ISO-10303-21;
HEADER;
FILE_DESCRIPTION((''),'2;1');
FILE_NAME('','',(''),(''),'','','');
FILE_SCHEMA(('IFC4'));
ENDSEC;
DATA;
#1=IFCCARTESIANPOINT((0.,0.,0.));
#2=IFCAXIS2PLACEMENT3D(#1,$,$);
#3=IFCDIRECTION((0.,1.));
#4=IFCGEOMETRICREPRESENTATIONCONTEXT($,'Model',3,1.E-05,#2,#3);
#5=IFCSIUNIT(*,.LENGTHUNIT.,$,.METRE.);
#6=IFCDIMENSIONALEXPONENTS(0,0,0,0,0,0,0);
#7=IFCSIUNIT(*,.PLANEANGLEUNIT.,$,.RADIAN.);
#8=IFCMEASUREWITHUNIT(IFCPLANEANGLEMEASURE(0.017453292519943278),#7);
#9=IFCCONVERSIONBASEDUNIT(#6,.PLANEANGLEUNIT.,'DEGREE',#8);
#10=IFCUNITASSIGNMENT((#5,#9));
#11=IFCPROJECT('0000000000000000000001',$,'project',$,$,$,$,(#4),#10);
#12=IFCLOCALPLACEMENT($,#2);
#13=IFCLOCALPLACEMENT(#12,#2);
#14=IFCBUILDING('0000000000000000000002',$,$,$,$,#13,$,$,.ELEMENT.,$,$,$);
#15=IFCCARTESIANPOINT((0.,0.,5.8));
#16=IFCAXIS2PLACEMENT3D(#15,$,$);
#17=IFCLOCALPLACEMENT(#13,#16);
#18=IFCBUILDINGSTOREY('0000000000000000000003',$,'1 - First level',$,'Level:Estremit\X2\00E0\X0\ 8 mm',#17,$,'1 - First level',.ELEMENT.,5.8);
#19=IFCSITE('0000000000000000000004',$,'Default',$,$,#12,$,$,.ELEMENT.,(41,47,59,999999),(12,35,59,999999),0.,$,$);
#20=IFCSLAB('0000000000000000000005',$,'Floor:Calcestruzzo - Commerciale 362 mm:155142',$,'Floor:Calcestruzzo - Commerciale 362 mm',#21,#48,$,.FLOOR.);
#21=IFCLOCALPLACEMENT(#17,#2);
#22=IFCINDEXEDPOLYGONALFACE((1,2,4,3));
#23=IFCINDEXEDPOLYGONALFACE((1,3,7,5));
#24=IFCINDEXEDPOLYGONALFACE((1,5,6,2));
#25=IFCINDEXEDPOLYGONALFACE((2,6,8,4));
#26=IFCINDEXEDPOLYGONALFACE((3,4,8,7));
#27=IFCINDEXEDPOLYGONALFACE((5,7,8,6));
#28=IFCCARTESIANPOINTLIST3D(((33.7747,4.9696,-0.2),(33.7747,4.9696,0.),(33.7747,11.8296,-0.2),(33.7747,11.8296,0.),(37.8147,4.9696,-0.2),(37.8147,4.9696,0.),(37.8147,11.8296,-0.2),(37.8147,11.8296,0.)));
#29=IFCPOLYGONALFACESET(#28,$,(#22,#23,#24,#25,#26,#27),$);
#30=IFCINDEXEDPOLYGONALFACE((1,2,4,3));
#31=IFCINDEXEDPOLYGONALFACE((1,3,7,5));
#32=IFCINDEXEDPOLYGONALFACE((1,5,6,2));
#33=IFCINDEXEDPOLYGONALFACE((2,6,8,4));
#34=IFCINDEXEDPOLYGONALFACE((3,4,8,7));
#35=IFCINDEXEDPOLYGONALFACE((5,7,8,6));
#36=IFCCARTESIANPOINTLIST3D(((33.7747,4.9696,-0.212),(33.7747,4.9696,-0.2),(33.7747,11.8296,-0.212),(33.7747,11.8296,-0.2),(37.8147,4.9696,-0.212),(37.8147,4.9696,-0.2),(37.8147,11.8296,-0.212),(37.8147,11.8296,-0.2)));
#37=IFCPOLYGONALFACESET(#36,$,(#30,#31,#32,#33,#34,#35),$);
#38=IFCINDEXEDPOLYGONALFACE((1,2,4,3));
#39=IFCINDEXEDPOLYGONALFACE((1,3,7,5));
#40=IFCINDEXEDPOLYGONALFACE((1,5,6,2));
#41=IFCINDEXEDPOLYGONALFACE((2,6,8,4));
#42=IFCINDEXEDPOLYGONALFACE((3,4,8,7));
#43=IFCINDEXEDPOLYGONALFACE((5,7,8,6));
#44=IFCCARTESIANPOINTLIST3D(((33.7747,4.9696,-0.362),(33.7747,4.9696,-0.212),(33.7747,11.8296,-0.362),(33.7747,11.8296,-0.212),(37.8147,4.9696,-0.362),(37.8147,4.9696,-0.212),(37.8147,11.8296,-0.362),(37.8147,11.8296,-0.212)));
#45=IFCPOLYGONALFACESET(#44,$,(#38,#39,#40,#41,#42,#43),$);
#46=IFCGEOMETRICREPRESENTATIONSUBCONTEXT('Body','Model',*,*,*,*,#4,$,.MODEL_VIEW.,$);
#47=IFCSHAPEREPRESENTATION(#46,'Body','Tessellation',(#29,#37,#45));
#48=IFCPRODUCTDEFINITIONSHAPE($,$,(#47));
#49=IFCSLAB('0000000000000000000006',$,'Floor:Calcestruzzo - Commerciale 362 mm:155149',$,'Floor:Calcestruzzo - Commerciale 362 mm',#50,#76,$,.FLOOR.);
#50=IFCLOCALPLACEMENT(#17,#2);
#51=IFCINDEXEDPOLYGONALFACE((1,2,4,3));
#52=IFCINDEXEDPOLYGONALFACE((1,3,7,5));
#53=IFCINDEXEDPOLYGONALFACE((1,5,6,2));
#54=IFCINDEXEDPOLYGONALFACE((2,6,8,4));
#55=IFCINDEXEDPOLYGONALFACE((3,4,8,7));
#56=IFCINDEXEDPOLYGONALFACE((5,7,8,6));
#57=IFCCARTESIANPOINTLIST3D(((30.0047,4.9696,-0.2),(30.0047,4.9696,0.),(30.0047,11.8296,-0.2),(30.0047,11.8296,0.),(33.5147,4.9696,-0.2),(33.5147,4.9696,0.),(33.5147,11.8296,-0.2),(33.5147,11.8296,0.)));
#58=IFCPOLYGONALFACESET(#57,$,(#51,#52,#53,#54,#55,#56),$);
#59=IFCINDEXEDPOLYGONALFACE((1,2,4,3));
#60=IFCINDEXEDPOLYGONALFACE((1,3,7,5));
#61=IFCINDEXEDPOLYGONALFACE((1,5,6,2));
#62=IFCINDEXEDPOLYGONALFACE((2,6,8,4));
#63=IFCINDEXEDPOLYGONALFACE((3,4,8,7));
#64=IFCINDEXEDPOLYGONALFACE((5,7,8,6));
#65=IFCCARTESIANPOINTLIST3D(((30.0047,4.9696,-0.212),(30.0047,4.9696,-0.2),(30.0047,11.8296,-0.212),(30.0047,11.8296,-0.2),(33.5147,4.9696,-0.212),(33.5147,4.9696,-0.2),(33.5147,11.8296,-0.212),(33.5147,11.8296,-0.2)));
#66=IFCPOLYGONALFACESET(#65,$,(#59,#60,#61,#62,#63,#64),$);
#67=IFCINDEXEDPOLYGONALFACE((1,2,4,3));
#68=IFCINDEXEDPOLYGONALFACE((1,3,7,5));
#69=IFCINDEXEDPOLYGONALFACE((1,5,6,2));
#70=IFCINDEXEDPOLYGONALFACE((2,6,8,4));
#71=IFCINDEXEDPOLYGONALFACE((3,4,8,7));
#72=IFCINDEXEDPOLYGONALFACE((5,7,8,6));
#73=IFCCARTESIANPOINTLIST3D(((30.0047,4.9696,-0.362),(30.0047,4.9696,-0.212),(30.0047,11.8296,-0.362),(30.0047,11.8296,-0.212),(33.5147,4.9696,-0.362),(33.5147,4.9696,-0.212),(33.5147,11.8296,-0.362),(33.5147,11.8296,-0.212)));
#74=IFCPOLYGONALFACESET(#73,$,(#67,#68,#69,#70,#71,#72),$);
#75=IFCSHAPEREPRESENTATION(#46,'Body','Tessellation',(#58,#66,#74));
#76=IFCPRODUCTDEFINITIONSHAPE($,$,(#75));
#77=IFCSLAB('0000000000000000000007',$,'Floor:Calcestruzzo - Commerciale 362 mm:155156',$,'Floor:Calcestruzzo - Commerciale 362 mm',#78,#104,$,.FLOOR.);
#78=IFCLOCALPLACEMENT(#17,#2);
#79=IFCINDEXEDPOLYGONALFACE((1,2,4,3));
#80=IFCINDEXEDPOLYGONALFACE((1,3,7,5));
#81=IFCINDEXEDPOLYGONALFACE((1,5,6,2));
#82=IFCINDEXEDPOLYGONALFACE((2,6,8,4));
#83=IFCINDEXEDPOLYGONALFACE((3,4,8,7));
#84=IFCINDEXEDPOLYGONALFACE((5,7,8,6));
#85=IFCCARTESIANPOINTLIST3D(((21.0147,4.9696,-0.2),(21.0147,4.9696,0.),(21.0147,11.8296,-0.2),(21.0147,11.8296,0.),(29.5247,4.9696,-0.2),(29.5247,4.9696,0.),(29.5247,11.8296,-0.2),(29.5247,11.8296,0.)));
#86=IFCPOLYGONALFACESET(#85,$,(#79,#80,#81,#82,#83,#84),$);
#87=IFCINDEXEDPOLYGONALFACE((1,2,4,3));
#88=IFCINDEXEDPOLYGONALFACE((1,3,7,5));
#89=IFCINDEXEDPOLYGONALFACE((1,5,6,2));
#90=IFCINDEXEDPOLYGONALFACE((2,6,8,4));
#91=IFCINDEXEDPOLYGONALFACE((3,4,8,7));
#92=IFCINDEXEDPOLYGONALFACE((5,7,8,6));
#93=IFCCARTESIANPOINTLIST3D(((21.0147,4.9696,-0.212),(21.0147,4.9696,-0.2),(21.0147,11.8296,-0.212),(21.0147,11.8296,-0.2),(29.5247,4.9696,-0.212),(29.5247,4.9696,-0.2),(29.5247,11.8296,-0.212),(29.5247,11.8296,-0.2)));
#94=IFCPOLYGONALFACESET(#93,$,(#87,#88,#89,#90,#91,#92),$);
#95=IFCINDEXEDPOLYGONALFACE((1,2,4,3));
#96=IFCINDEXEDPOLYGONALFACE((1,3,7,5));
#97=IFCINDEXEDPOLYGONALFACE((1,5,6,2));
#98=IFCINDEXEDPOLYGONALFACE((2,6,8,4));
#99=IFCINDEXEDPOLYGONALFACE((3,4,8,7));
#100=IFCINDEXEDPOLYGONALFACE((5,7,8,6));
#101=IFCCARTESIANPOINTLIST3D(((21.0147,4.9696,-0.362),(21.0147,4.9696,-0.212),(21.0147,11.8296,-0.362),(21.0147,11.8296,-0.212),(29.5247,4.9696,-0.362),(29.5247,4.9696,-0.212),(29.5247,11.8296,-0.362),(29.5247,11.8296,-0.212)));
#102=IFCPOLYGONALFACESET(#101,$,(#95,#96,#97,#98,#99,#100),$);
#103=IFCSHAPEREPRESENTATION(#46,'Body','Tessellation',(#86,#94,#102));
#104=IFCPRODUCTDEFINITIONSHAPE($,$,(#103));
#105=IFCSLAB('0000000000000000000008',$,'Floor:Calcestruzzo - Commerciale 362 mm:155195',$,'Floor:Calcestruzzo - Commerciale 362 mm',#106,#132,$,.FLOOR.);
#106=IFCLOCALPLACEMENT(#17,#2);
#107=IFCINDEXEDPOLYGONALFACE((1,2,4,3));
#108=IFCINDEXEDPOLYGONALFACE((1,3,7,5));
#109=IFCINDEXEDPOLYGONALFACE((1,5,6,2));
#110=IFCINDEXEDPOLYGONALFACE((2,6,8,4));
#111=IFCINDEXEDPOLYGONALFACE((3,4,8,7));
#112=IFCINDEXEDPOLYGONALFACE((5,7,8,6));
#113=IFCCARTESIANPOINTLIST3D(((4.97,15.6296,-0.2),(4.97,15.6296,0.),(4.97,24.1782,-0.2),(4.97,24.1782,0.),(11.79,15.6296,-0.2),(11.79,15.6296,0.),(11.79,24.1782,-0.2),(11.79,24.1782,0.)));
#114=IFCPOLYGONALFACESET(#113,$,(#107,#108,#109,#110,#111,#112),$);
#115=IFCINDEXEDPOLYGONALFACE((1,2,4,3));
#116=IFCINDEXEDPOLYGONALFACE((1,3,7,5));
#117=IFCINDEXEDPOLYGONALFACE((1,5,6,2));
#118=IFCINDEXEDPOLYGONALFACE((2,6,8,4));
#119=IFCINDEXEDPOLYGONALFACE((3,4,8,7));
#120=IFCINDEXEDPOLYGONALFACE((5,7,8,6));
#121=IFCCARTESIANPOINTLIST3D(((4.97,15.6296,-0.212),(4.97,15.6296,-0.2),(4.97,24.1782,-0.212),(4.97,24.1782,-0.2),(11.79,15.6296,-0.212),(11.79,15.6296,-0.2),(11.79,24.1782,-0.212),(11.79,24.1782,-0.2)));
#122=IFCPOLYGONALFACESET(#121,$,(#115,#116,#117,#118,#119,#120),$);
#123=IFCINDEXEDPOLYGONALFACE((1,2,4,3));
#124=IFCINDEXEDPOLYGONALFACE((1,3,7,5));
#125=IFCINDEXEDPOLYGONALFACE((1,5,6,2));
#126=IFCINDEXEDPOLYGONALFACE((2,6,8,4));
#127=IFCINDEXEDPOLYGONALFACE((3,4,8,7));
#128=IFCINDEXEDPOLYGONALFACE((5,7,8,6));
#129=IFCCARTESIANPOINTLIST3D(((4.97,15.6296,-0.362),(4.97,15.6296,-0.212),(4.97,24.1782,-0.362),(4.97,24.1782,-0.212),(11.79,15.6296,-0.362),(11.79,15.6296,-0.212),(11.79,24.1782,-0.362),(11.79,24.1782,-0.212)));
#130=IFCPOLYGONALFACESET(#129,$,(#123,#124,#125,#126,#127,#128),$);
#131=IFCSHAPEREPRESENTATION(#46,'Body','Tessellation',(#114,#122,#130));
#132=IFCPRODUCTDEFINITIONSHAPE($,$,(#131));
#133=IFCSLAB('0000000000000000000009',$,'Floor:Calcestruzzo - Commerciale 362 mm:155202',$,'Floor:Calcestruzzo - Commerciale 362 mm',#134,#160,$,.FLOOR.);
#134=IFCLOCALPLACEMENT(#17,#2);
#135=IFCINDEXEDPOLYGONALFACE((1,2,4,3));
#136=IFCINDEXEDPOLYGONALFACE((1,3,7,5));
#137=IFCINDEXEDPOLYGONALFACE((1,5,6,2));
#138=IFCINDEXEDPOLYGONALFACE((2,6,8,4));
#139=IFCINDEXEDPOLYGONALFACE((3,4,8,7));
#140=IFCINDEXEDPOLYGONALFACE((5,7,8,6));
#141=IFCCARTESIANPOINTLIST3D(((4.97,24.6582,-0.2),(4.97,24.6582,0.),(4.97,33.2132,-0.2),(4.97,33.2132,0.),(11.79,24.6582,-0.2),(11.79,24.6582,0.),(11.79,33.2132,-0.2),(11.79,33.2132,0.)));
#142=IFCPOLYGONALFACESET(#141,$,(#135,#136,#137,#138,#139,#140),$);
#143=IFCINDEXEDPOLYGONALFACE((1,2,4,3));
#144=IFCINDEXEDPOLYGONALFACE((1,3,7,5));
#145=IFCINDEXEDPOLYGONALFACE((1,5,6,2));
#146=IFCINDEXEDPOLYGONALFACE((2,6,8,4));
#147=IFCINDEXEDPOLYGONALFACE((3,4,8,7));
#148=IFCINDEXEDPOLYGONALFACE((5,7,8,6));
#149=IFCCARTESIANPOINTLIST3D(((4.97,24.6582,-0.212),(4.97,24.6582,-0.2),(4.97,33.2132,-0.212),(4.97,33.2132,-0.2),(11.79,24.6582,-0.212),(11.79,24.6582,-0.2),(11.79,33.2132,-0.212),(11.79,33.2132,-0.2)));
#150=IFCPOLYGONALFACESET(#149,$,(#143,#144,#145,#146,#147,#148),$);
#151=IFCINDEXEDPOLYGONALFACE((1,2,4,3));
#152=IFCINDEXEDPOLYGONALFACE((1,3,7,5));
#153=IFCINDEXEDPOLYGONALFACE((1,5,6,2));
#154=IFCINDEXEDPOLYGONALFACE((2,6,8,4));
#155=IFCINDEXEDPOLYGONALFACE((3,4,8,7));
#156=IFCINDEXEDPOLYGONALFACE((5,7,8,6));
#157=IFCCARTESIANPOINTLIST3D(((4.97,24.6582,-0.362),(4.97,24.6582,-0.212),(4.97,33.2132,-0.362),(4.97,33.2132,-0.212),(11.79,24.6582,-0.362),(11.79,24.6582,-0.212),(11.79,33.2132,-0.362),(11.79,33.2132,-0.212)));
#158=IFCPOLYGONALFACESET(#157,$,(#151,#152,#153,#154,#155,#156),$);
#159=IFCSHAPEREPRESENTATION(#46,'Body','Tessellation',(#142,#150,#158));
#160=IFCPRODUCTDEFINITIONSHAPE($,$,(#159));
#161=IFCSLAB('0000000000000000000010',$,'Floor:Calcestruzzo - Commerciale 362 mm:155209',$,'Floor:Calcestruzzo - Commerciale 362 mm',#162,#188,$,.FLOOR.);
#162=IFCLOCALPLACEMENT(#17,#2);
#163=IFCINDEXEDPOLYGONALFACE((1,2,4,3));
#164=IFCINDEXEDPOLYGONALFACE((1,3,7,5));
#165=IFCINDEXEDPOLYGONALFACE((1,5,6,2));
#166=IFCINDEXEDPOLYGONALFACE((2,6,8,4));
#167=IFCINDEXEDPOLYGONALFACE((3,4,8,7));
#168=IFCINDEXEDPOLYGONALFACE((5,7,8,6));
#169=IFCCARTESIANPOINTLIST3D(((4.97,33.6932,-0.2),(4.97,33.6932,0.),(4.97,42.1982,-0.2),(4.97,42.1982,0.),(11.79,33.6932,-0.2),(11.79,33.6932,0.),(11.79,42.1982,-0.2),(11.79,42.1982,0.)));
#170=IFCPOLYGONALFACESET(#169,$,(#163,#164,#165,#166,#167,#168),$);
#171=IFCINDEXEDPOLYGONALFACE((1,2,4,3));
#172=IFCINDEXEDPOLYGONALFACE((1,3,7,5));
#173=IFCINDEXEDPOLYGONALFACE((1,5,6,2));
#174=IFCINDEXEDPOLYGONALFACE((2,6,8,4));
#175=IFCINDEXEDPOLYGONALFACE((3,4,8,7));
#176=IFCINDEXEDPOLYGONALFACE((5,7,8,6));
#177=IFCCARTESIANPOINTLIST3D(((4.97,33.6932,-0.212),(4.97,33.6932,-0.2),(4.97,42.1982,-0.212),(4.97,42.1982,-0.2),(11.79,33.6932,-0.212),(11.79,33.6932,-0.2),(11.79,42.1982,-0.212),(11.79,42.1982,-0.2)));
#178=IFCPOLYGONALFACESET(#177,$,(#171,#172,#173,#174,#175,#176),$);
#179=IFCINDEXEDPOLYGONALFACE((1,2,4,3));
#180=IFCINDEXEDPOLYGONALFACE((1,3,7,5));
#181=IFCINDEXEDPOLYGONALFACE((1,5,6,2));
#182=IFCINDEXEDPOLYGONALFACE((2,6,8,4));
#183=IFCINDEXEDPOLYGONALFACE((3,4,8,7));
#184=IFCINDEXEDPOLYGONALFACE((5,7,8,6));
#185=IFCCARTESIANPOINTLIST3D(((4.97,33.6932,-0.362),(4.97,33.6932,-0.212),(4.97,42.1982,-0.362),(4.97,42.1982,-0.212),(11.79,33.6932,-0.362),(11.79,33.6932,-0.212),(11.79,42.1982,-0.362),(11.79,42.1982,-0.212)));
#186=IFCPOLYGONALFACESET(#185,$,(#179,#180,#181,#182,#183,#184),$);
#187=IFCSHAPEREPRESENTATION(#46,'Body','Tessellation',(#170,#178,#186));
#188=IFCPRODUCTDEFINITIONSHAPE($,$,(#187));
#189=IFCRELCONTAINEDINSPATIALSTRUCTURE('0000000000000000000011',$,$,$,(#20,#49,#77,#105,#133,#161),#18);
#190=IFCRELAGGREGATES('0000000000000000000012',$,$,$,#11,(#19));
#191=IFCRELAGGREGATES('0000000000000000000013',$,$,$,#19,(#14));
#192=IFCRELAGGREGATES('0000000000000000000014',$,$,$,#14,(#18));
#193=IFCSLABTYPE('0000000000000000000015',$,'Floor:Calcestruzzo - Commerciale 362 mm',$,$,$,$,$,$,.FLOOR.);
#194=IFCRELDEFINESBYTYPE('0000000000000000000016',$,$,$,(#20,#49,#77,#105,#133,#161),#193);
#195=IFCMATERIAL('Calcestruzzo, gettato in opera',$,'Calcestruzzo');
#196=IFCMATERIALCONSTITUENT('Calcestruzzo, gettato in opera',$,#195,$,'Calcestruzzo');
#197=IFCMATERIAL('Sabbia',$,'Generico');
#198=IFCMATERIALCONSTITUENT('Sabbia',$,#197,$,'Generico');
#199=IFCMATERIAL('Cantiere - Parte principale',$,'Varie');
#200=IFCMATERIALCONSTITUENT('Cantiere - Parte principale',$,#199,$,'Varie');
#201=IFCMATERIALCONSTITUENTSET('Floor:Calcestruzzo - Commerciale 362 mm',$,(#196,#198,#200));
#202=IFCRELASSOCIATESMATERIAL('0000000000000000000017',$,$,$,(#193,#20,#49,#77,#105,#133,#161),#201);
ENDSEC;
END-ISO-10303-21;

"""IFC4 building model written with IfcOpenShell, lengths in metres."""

from ifc_helpers import new_model, entity, si_unit, converted_unit, direction, frame, origin, place, context, subcontext, project, spatial, indexed_curve, outline, extrude, material, constituent, constituent_set, type_object, element, save


model = new_model("IFC4")

# Units and contexts
model_context = context("Model", 3, precision=1e-05, world=origin(), true_north=direction((0.0, 1.0)))
body_context = subcontext(model_context, "Body", "Model", "MODEL_VIEW")
ifc_project = project(units=[si_unit("LENGTHUNIT", "METRE"), converted_unit("PLANEANGLEUNIT", "DEGREE", entity("IfcPlaneAngleMeasure", 0.017453292519943278), si_unit("PLANEANGLEUNIT", "RADIAN"), dimensions=[0, 0, 0, 0, 0, 0, 0])], contexts=[model_context])

# Site, building, storey
site_placement = place(None, origin())
site = spatial("IfcSite", under=ifc_project, at=site_placement, Name="Default", CompositionType="ELEMENT", RefLatitude=(41, 47, 59, 999999), RefLongitude=(12, 35, 59, 999999), RefElevation=0.0)
building_placement = place(site_placement, origin())
building = spatial("IfcBuilding", under=site, at=building_placement, CompositionType="ELEMENT")
storey_placement = place(building_placement, frame((0.0, 0.0, 5.8)))
storey = spatial("IfcBuildingStorey", under=building, at=storey_placement, Name="1 - First level", ObjectType="Level:Estremità 8 mm", LongName="1 - First level", CompositionType="ELEMENT", Elevation=5.8)

# Slabs
ifc_material_1 = material(Name="Calcestruzzo, gettato in opera", Category="Calcestruzzo")
ifc_constituent_1 = constituent(ifc_material_1, Name="Calcestruzzo, gettato in opera", Category="Calcestruzzo")
ifc_material_2 = material(Name="Sabbia", Category="Generico")
ifc_constituent_2 = constituent(ifc_material_2, Name="Sabbia", Category="Generico")
ifc_material_3 = material(Name="Cantiere - Parte principale", Category="Varie")
ifc_constituent_3 = constituent(ifc_material_3, Name="Cantiere - Parte principale", Category="Varie")
ifc_constituent_set = constituent_set(constituents=[ifc_constituent_1, ifc_constituent_2, ifc_constituent_3], Name="Floor:Calcestruzzo - Commerciale 362 mm")
slab_type = type_object("IfcSlabType", Name="Floor:Calcestruzzo - Commerciale 362 mm", PredefinedType="FLOOR", material=ifc_constituent_set)
slab_1_placement = place(storey_placement, origin())
element("IfcSlab", 1, at=slab_1_placement, inside=storey, type_object=slab_type, material=ifc_constituent_set, Name="Floor:Calcestruzzo - Commerciale 362 mm:155142", ObjectType="Floor:Calcestruzzo - Commerciale 362 mm", PredefinedType="FLOOR", context=body_context, shape_type="SweptSolid", body=[
    extrude(outline(indexed_curve([(-2.02, -3.43), (2.02, -3.43), (2.02, 3.43), (-2.02, 3.43), (-2.02, -3.43)], self_intersect=False)), frame((35.7947, 8.3996, -0.2)), (0.0, 0.0, 1.0), 0.2),
    extrude(outline(indexed_curve([(-2.02, -3.43), (2.02, -3.43), (2.02, 3.43), (-2.02, 3.43), (-2.02, -3.43)], self_intersect=False)), frame((35.7947, 8.3996, -0.212)), (0.0, 0.0, 1.0), 0.012),
    extrude(outline(indexed_curve([(-2.02, -3.43), (2.02, -3.43), (2.02, 3.43), (-2.02, 3.43), (-2.02, -3.43)], self_intersect=False)), frame((35.7947, 8.3996, -0.362)), (0.0, 0.0, 1.0), 0.15),
])
slab_2_placement = place(storey_placement, origin())
element("IfcSlab", 2, at=slab_2_placement, inside=storey, type_object=slab_type, material=ifc_constituent_set, Name="Floor:Calcestruzzo - Commerciale 362 mm:155149", ObjectType="Floor:Calcestruzzo - Commerciale 362 mm", PredefinedType="FLOOR", context=body_context, shape_type="SweptSolid", body=[
    extrude(outline(indexed_curve([(-1.755, -3.43), (1.755, -3.43), (1.755, 3.43), (-1.755, 3.43), (-1.755, -3.43)], self_intersect=False)), frame((31.7597, 8.3996, -0.2)), (0.0, 0.0, 1.0), 0.2),
    extrude(outline(indexed_curve([(-1.755, -3.43), (1.755, -3.43), (1.755, 3.43), (-1.755, 3.43), (-1.755, -3.43)], self_intersect=False)), frame((31.7597, 8.3996, -0.212)), (0.0, 0.0, 1.0), 0.012),
    extrude(outline(indexed_curve([(-1.755, -3.43), (1.755, -3.43), (1.755, 3.43), (-1.755, 3.43), (-1.755, -3.43)], self_intersect=False)), frame((31.7597, 8.3996, -0.362)), (0.0, 0.0, 1.0), 0.15),
])
slab_3_placement = place(storey_placement, origin())
element("IfcSlab", 3, at=slab_3_placement, inside=storey, type_object=slab_type, material=ifc_constituent_set, Name="Floor:Calcestruzzo - Commerciale 362 mm:155156", ObjectType="Floor:Calcestruzzo - Commerciale 362 mm", PredefinedType="FLOOR", context=body_context, shape_type="SweptSolid", body=[
    extrude(outline(indexed_curve([(-3.43, -4.255), (3.43, -4.255), (3.43, 4.255), (-3.43, 4.255), (-3.43, -4.255)], self_intersect=False)), frame((25.2697, 8.3996, -0.2), z_axis=(0.0, 0.0, 1.0), x_axis=(0.0, 1.0, 0.0)), (0.0, 0.0, 1.0), 0.2),
    extrude(outline(indexed_curve([(-3.43, -4.255), (3.43, -4.255), (3.43, 4.255), (-3.43, 4.255), (-3.43, -4.255)], self_intersect=False)), frame((25.2697, 8.3996, -0.212), z_axis=(0.0, 0.0, 1.0), x_axis=(0.0, 1.0, 0.0)), (0.0, 0.0, 1.0), 0.012),
    extrude(outline(indexed_curve([(-3.43, -4.255), (3.43, -4.255), (3.43, 4.255), (-3.43, 4.255), (-3.43, -4.255)], self_intersect=False)), frame((25.2697, 8.3996, -0.362), z_axis=(0.0, 0.0, 1.0), x_axis=(0.0, 1.0, 0.0)), (0.0, 0.0, 1.0), 0.15),
])
slab_4_placement = place(storey_placement, origin())
element("IfcSlab", 4, at=slab_4_placement, inside=storey, type_object=slab_type, material=ifc_constituent_set, Name="Floor:Calcestruzzo - Commerciale 362 mm:155195", ObjectType="Floor:Calcestruzzo - Commerciale 362 mm", PredefinedType="FLOOR", context=body_context, shape_type="SweptSolid", body=[
    extrude(outline(indexed_curve([(-3.41, -4.2743), (3.41, -4.2743), (3.41, 4.2743), (-3.41, 4.2743), (-3.41, -4.2743)], self_intersect=False)), frame((8.38, 19.9039, -0.2), z_axis=(0.0, 0.0, 1.0), x_axis=(-1.0, 0.0, 0.0)), (0.0, 0.0, 1.0), 0.2),
    extrude(outline(indexed_curve([(-3.41, -4.2743), (3.41, -4.2743), (3.41, 4.2743), (-3.41, 4.2743), (-3.41, -4.2743)], self_intersect=False)), frame((8.38, 19.9039, -0.212), z_axis=(0.0, 0.0, 1.0), x_axis=(-1.0, 0.0, 0.0)), (0.0, 0.0, 1.0), 0.012),
    extrude(outline(indexed_curve([(-3.41, -4.2743), (3.41, -4.2743), (3.41, 4.2743), (-3.41, 4.2743), (-3.41, -4.2743)], self_intersect=False)), frame((8.38, 19.9039, -0.362), z_axis=(0.0, 0.0, 1.0), x_axis=(-1.0, 0.0, 0.0)), (0.0, 0.0, 1.0), 0.15),
])
slab_5_placement = place(storey_placement, origin())
element("IfcSlab", 5, at=slab_5_placement, inside=storey, type_object=slab_type, material=ifc_constituent_set, Name="Floor:Calcestruzzo - Commerciale 362 mm:155202", ObjectType="Floor:Calcestruzzo - Commerciale 362 mm", PredefinedType="FLOOR", context=body_context, shape_type="SweptSolid", body=[
    extrude(outline(indexed_curve([(-3.41, -4.2775), (3.41, -4.2775), (3.41, 4.2775), (-3.41, 4.2775), (-3.41, -4.2775)], self_intersect=False)), frame((8.38, 28.9357, -0.2)), (0.0, 0.0, 1.0), 0.2),
    extrude(outline(indexed_curve([(-3.41, -4.2775), (3.41, -4.2775), (3.41, 4.2775), (-3.41, 4.2775), (-3.41, -4.2775)], self_intersect=False)), frame((8.38, 28.9357, -0.212)), (0.0, 0.0, 1.0), 0.012),
    extrude(outline(indexed_curve([(-3.41, -4.2775), (3.41, -4.2775), (3.41, 4.2775), (-3.41, 4.2775), (-3.41, -4.2775)], self_intersect=False)), frame((8.38, 28.9357, -0.362)), (0.0, 0.0, 1.0), 0.15),
])
slab_6_placement = place(storey_placement, origin())
element("IfcSlab", 6, at=slab_6_placement, inside=storey, type_object=slab_type, material=ifc_constituent_set, Name="Floor:Calcestruzzo - Commerciale 362 mm:155209", ObjectType="Floor:Calcestruzzo - Commerciale 362 mm", PredefinedType="FLOOR", context=body_context, shape_type="SweptSolid", body=[
    extrude(outline(indexed_curve([(-3.41, -4.2525), (3.41, -4.2525), (3.41, 4.2525), (-3.41, 4.2525), (-3.41, -4.2525)], self_intersect=False)), frame((8.38, 37.9457, -0.2)), (0.0, 0.0, 1.0), 0.2),
    extrude(outline(indexed_curve([(-3.41, -4.2525), (3.41, -4.2525), (3.41, 4.2525), (-3.41, 4.2525), (-3.41, -4.2525)], self_intersect=False)), frame((8.38, 37.9457, -0.212)), (0.0, 0.0, 1.0), 0.012),
    extrude(outline(indexed_curve([(-3.41, -4.2525), (3.41, -4.2525), (3.41, 4.2525), (-3.41, 4.2525), (-3.41, -4.2525)], self_intersect=False)), frame((8.38, 37.9457, -0.362)), (0.0, 0.0, 1.0), 0.15),
])

save(model, "model.ifc")
